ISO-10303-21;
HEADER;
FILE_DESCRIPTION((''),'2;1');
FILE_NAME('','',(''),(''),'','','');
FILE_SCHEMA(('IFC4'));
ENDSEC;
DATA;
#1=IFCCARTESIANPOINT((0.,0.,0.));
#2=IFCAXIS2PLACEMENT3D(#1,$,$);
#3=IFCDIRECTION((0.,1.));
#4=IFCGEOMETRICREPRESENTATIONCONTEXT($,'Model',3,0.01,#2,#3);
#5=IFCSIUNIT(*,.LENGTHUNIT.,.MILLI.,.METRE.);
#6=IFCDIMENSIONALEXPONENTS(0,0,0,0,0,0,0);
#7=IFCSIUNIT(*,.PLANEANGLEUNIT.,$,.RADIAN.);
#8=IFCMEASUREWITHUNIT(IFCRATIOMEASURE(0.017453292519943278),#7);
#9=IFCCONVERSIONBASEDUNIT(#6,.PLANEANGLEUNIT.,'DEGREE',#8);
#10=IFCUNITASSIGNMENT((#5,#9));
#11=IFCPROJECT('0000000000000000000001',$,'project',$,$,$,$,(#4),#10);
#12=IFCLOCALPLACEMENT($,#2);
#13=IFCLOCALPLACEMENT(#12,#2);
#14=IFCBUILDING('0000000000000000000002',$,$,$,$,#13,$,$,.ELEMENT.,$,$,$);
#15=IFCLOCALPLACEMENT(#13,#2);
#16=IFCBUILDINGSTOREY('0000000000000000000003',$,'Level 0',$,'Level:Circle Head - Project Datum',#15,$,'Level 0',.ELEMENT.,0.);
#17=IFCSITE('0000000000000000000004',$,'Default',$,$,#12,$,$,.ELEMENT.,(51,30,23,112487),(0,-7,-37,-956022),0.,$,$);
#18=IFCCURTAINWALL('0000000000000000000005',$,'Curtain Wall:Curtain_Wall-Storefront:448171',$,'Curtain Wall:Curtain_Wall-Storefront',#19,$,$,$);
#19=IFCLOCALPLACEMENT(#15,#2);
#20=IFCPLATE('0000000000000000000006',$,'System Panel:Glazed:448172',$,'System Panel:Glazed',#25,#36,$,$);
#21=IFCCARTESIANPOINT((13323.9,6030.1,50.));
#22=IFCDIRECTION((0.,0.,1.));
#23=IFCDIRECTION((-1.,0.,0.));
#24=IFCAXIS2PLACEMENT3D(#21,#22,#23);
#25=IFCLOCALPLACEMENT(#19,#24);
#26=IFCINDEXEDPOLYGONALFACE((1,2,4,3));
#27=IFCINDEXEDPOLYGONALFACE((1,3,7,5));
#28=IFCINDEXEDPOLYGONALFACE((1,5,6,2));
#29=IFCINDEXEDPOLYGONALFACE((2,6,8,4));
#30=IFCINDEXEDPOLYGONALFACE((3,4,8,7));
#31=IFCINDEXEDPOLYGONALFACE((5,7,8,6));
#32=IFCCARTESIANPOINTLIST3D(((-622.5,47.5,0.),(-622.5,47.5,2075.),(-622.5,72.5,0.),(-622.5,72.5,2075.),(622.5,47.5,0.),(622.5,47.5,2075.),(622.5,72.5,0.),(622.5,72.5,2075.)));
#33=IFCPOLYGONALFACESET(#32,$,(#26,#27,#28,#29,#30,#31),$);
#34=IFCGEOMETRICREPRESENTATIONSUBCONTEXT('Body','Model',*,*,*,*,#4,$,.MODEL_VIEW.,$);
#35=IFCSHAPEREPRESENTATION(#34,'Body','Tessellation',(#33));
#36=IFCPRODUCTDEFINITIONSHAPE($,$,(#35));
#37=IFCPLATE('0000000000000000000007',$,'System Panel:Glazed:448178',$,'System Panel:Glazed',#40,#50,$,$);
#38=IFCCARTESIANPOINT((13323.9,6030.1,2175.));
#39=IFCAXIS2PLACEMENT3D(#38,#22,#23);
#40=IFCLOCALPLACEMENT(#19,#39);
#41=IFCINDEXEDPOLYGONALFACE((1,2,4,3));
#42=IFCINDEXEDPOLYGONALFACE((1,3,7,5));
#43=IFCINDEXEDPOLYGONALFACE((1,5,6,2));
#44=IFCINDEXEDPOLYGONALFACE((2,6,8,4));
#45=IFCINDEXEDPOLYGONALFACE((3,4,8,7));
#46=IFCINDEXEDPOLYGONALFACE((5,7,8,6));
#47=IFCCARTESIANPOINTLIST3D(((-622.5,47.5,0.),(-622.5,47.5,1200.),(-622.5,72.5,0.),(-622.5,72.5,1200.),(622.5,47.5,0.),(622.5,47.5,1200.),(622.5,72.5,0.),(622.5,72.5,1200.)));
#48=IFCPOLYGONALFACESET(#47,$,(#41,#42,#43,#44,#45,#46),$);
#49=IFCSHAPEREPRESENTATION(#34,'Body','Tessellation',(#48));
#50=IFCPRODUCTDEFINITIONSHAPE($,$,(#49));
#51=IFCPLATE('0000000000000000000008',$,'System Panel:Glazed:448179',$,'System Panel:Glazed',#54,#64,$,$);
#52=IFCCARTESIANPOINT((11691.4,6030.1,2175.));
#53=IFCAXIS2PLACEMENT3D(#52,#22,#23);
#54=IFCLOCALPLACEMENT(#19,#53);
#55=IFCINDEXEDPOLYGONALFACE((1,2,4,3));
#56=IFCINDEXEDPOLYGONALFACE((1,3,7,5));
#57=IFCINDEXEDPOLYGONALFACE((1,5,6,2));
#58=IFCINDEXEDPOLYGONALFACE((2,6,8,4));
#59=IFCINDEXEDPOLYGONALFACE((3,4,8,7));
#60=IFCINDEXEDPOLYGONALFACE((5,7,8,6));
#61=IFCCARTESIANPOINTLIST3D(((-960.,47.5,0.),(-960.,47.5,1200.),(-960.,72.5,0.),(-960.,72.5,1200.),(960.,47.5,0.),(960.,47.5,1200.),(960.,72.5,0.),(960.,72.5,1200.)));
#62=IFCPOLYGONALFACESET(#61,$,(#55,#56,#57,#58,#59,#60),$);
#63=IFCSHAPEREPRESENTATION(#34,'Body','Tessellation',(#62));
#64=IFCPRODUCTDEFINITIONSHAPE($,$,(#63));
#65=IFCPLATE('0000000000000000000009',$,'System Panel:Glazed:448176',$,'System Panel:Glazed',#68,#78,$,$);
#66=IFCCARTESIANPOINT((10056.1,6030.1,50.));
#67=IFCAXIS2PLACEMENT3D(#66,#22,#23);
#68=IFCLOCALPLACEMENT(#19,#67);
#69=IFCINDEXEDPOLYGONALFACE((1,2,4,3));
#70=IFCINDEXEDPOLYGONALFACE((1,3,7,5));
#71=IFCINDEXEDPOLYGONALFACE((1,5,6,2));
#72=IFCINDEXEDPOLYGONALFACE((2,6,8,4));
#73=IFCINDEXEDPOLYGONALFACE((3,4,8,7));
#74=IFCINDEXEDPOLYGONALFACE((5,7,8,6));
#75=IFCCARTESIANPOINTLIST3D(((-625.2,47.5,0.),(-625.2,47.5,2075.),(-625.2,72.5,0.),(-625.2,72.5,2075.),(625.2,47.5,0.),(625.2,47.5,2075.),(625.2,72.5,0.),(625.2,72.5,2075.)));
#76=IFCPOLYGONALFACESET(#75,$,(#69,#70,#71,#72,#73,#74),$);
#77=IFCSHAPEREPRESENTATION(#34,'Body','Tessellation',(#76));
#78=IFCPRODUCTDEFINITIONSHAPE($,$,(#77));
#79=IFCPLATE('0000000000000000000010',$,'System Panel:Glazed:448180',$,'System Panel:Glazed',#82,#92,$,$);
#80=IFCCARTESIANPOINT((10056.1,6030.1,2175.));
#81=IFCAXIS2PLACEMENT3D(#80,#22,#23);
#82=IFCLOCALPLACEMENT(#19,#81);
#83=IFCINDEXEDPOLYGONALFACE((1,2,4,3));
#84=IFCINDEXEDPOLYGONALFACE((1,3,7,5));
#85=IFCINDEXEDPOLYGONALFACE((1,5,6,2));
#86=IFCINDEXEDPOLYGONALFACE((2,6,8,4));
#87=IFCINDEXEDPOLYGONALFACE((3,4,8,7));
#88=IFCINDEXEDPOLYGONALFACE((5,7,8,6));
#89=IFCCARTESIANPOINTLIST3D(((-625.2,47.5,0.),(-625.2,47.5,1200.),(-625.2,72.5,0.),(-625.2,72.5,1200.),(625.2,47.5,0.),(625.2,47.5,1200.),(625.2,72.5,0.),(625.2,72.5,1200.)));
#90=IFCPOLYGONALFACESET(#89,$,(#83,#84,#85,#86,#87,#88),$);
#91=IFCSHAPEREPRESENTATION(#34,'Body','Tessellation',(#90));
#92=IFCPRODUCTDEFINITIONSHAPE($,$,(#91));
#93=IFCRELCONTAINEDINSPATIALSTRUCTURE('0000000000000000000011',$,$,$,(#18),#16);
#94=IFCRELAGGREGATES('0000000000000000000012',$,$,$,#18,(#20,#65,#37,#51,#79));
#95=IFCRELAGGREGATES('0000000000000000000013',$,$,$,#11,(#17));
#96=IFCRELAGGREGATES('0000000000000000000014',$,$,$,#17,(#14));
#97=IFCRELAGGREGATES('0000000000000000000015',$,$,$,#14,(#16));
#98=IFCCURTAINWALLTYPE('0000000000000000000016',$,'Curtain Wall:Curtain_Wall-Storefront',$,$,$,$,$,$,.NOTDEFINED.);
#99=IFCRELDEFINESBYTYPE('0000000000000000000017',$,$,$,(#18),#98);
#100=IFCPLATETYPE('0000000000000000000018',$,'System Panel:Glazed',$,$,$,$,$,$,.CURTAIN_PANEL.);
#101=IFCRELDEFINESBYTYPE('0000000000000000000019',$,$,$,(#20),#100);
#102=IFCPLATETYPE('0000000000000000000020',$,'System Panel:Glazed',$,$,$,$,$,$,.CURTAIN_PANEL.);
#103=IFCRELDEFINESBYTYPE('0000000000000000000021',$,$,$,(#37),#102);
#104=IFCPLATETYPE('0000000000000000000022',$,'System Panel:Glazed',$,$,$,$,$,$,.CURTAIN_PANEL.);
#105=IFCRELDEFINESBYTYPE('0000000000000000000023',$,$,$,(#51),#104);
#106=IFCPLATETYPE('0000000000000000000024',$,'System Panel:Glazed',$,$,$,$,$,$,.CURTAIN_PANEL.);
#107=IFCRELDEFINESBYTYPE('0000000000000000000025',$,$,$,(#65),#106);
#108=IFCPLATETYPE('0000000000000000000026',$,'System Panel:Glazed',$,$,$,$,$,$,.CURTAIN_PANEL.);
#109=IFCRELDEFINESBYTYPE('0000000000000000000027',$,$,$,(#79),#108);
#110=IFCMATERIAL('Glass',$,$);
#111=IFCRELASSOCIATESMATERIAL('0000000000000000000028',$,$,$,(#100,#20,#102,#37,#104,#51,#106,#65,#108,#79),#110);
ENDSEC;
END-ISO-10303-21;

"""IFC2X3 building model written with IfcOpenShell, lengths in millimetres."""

from ifc_helpers import new_model, entity, si_unit, converted_unit, direction, frame, origin, origin_2d_with_axis, place, context, subcontext, project, spatial, rectangle, extrude, source, transform, mapped, material, type_object, type_shapes, element, aggregate, save


model = new_model("IFC2X3")

# Units and contexts
model_context = context("Model", 3, precision=0.01, world=origin(), true_north=direction((0.0, 1.0)))
body_context = subcontext(model_context, "Body", "Model", "MODEL_VIEW")
ifc_project = project(units=[si_unit("LENGTHUNIT", "METRE", prefix="MILLI"), converted_unit("PLANEANGLEUNIT", "DEGREE", entity("IfcRatioMeasure", 0.017453292519943278), si_unit("PLANEANGLEUNIT", "RADIAN"), dimensions=[0, 0, 0, 0, 0, 0, 0])], contexts=[model_context])

# Site, building, storey
site_placement = place(None, origin())
site = spatial("IfcSite", under=ifc_project, at=site_placement, Name="Default", CompositionType="ELEMENT", RefLatitude=(51, 30, 23, 112487), RefLongitude=(0, -7, -37, -956022), RefElevation=0.0)
building_placement = place(site_placement, origin())
building = spatial("IfcBuilding", under=site, at=building_placement, CompositionType="ELEMENT")
storey_placement = place(building_placement, origin())
storey = spatial("IfcBuildingStorey", under=building, at=storey_placement, Name="Level 0", ObjectType="Level:Circle Head - Project Datum", LongName="Level 0", CompositionType="ELEMENT", Elevation=0.0)

# Curtain wall, plates
curtain_wall_type = type_object("IfcCurtainWallType", Name="Curtain Wall:Curtain_Wall-Storefront", PredefinedType="NOTDEFINED")
curtain_wall_placement = place(storey_placement, origin())
curtain_wall = element("IfcCurtainWall", 1, at=curtain_wall_placement, inside=storey, type_object=curtain_wall_type, Name="Curtain Wall:Curtain_Wall-Storefront:448171", ObjectType="Curtain Wall:Curtain_Wall-Storefront")
ifc_material_1 = material(Name="Glass")
plate_type_1 = type_object("IfcPlateType", Name="System Panel:Glazed", PredefinedType="CURTAIN_PANEL", material=ifc_material_1)
shared_shape_1 = source(origin(), body_context, "Body", "SweptSolid", [
    extrude(rectangle(XDim=25.0, YDim=1245.0, at=origin_2d_with_axis()), frame((0.0, 60.0, 0.0), z_axis=(0.0, 0.0, 1.0), x_axis=(0.0, 1.0, 0.0)), (0.0, 0.0, 1.0), 2075.0),
])
type_shapes(plate_type_1, [shared_shape_1])
plate_1_placement = place(curtain_wall_placement, frame((13323.9, 6030.1, 50.0), z_axis=(0.0, 0.0, 1.0), x_axis=(-1.0, 0.0, 0.0)))
plate_1 = element("IfcPlate", 2, at=plate_1_placement, type_object=plate_type_1, material=ifc_material_1, Name="System Panel:Glazed:448172", ObjectType="System Panel:Glazed", context=body_context, shape_type="MappedRepresentation", body=[
    mapped(shared_shape_1, transform((0.0, 0.0, 0.0), scale=1.0)),
])
plate_type_2 = type_object("IfcPlateType", Name="System Panel:Glazed", PredefinedType="CURTAIN_PANEL", material=ifc_material_1)
shared_shape_2 = source(origin(), body_context, "Body", "SweptSolid", [
    extrude(rectangle(XDim=25.0, YDim=1245.0, at=origin_2d_with_axis()), frame((0.0, 60.0, 0.0), z_axis=(0.0, 0.0, 1.0), x_axis=(0.0, 1.0, 0.0)), (0.0, 0.0, 1.0), 1200.0),
])
type_shapes(plate_type_2, [shared_shape_2])
plate_2_placement = place(curtain_wall_placement, frame((13323.9, 6030.1, 2175.0), z_axis=(0.0, 0.0, 1.0), x_axis=(-1.0, 0.0, 0.0)))
plate_2 = element("IfcPlate", 3, at=plate_2_placement, type_object=plate_type_2, material=ifc_material_1, Name="System Panel:Glazed:448178", ObjectType="System Panel:Glazed", context=body_context, shape_type="MappedRepresentation", body=[
    mapped(shared_shape_2, transform((0.0, 0.0, 0.0), scale=1.0)),
])
plate_type_3 = type_object("IfcPlateType", Name="System Panel:Glazed", PredefinedType="CURTAIN_PANEL", material=ifc_material_1)
shared_shape_3 = source(origin(), body_context, "Body", "SweptSolid", [
    extrude(rectangle(XDim=25.0, YDim=1920.0, at=origin_2d_with_axis()), frame((0.0, 60.0, 0.0), z_axis=(0.0, 0.0, 1.0), x_axis=(0.0, 1.0, 0.0)), (0.0, 0.0, 1.0), 1200.0),
])
type_shapes(plate_type_3, [shared_shape_3])
plate_3_placement = place(curtain_wall_placement, frame((11691.4, 6030.1, 2175.0), z_axis=(0.0, 0.0, 1.0), x_axis=(-1.0, 0.0, 0.0)))
plate_3 = element("IfcPlate", 4, at=plate_3_placement, type_object=plate_type_3, material=ifc_material_1, Name="System Panel:Glazed:448179", ObjectType="System Panel:Glazed", context=body_context, shape_type="MappedRepresentation", body=[
    mapped(shared_shape_3, transform((0.0, 0.0, 0.0), scale=1.0)),
])
plate_type_4 = type_object("IfcPlateType", Name="System Panel:Glazed", PredefinedType="CURTAIN_PANEL", material=ifc_material_1)
shared_shape_4 = source(origin(), body_context, "Body", "SweptSolid", [
    extrude(rectangle(XDim=25.0, YDim=1250.5, at=origin_2d_with_axis()), frame((0.0, 60.0, 0.0), z_axis=(0.0, 0.0, 1.0), x_axis=(0.0, 1.0, 0.0)), (0.0, 0.0, 1.0), 2075.0),
])
type_shapes(plate_type_4, [shared_shape_4])
plate_4_placement = place(curtain_wall_placement, frame((10056.1, 6030.1, 50.0), z_axis=(0.0, 0.0, 1.0), x_axis=(-1.0, 0.0, 0.0)))
plate_4 = element("IfcPlate", 5, at=plate_4_placement, type_object=plate_type_4, material=ifc_material_1, Name="System Panel:Glazed:448176", ObjectType="System Panel:Glazed", context=body_context, shape_type="MappedRepresentation", body=[
    mapped(shared_shape_4, transform((0.0, 0.0, 0.0), scale=1.0)),
])
plate_type_5 = type_object("IfcPlateType", Name="System Panel:Glazed", PredefinedType="CURTAIN_PANEL", material=ifc_material_1)
shared_shape_5 = source(origin(), body_context, "Body", "SweptSolid", [
    extrude(rectangle(XDim=25.0, YDim=1250.5, at=origin_2d_with_axis()), frame((0.0, 60.0, 0.0), z_axis=(0.0, 0.0, 1.0), x_axis=(0.0, 1.0, 0.0)), (0.0, 0.0, 1.0), 1200.0),
])
type_shapes(plate_type_5, [shared_shape_5])
plate_5_placement = place(curtain_wall_placement, frame((10056.1, 6030.1, 2175.0), z_axis=(0.0, 0.0, 1.0), x_axis=(-1.0, 0.0, 0.0)))
plate_5 = element("IfcPlate", 6, at=plate_5_placement, type_object=plate_type_5, material=ifc_material_1, Name="System Panel:Glazed:448180", ObjectType="System Panel:Glazed", context=body_context, shape_type="MappedRepresentation", body=[
    mapped(shared_shape_5, transform((0.0, 0.0, 0.0), scale=1.0)),
])
aggregate(curtain_wall, [plate_1, plate_4, plate_2, plate_3, plate_5])

save(model, "model.ifc")
